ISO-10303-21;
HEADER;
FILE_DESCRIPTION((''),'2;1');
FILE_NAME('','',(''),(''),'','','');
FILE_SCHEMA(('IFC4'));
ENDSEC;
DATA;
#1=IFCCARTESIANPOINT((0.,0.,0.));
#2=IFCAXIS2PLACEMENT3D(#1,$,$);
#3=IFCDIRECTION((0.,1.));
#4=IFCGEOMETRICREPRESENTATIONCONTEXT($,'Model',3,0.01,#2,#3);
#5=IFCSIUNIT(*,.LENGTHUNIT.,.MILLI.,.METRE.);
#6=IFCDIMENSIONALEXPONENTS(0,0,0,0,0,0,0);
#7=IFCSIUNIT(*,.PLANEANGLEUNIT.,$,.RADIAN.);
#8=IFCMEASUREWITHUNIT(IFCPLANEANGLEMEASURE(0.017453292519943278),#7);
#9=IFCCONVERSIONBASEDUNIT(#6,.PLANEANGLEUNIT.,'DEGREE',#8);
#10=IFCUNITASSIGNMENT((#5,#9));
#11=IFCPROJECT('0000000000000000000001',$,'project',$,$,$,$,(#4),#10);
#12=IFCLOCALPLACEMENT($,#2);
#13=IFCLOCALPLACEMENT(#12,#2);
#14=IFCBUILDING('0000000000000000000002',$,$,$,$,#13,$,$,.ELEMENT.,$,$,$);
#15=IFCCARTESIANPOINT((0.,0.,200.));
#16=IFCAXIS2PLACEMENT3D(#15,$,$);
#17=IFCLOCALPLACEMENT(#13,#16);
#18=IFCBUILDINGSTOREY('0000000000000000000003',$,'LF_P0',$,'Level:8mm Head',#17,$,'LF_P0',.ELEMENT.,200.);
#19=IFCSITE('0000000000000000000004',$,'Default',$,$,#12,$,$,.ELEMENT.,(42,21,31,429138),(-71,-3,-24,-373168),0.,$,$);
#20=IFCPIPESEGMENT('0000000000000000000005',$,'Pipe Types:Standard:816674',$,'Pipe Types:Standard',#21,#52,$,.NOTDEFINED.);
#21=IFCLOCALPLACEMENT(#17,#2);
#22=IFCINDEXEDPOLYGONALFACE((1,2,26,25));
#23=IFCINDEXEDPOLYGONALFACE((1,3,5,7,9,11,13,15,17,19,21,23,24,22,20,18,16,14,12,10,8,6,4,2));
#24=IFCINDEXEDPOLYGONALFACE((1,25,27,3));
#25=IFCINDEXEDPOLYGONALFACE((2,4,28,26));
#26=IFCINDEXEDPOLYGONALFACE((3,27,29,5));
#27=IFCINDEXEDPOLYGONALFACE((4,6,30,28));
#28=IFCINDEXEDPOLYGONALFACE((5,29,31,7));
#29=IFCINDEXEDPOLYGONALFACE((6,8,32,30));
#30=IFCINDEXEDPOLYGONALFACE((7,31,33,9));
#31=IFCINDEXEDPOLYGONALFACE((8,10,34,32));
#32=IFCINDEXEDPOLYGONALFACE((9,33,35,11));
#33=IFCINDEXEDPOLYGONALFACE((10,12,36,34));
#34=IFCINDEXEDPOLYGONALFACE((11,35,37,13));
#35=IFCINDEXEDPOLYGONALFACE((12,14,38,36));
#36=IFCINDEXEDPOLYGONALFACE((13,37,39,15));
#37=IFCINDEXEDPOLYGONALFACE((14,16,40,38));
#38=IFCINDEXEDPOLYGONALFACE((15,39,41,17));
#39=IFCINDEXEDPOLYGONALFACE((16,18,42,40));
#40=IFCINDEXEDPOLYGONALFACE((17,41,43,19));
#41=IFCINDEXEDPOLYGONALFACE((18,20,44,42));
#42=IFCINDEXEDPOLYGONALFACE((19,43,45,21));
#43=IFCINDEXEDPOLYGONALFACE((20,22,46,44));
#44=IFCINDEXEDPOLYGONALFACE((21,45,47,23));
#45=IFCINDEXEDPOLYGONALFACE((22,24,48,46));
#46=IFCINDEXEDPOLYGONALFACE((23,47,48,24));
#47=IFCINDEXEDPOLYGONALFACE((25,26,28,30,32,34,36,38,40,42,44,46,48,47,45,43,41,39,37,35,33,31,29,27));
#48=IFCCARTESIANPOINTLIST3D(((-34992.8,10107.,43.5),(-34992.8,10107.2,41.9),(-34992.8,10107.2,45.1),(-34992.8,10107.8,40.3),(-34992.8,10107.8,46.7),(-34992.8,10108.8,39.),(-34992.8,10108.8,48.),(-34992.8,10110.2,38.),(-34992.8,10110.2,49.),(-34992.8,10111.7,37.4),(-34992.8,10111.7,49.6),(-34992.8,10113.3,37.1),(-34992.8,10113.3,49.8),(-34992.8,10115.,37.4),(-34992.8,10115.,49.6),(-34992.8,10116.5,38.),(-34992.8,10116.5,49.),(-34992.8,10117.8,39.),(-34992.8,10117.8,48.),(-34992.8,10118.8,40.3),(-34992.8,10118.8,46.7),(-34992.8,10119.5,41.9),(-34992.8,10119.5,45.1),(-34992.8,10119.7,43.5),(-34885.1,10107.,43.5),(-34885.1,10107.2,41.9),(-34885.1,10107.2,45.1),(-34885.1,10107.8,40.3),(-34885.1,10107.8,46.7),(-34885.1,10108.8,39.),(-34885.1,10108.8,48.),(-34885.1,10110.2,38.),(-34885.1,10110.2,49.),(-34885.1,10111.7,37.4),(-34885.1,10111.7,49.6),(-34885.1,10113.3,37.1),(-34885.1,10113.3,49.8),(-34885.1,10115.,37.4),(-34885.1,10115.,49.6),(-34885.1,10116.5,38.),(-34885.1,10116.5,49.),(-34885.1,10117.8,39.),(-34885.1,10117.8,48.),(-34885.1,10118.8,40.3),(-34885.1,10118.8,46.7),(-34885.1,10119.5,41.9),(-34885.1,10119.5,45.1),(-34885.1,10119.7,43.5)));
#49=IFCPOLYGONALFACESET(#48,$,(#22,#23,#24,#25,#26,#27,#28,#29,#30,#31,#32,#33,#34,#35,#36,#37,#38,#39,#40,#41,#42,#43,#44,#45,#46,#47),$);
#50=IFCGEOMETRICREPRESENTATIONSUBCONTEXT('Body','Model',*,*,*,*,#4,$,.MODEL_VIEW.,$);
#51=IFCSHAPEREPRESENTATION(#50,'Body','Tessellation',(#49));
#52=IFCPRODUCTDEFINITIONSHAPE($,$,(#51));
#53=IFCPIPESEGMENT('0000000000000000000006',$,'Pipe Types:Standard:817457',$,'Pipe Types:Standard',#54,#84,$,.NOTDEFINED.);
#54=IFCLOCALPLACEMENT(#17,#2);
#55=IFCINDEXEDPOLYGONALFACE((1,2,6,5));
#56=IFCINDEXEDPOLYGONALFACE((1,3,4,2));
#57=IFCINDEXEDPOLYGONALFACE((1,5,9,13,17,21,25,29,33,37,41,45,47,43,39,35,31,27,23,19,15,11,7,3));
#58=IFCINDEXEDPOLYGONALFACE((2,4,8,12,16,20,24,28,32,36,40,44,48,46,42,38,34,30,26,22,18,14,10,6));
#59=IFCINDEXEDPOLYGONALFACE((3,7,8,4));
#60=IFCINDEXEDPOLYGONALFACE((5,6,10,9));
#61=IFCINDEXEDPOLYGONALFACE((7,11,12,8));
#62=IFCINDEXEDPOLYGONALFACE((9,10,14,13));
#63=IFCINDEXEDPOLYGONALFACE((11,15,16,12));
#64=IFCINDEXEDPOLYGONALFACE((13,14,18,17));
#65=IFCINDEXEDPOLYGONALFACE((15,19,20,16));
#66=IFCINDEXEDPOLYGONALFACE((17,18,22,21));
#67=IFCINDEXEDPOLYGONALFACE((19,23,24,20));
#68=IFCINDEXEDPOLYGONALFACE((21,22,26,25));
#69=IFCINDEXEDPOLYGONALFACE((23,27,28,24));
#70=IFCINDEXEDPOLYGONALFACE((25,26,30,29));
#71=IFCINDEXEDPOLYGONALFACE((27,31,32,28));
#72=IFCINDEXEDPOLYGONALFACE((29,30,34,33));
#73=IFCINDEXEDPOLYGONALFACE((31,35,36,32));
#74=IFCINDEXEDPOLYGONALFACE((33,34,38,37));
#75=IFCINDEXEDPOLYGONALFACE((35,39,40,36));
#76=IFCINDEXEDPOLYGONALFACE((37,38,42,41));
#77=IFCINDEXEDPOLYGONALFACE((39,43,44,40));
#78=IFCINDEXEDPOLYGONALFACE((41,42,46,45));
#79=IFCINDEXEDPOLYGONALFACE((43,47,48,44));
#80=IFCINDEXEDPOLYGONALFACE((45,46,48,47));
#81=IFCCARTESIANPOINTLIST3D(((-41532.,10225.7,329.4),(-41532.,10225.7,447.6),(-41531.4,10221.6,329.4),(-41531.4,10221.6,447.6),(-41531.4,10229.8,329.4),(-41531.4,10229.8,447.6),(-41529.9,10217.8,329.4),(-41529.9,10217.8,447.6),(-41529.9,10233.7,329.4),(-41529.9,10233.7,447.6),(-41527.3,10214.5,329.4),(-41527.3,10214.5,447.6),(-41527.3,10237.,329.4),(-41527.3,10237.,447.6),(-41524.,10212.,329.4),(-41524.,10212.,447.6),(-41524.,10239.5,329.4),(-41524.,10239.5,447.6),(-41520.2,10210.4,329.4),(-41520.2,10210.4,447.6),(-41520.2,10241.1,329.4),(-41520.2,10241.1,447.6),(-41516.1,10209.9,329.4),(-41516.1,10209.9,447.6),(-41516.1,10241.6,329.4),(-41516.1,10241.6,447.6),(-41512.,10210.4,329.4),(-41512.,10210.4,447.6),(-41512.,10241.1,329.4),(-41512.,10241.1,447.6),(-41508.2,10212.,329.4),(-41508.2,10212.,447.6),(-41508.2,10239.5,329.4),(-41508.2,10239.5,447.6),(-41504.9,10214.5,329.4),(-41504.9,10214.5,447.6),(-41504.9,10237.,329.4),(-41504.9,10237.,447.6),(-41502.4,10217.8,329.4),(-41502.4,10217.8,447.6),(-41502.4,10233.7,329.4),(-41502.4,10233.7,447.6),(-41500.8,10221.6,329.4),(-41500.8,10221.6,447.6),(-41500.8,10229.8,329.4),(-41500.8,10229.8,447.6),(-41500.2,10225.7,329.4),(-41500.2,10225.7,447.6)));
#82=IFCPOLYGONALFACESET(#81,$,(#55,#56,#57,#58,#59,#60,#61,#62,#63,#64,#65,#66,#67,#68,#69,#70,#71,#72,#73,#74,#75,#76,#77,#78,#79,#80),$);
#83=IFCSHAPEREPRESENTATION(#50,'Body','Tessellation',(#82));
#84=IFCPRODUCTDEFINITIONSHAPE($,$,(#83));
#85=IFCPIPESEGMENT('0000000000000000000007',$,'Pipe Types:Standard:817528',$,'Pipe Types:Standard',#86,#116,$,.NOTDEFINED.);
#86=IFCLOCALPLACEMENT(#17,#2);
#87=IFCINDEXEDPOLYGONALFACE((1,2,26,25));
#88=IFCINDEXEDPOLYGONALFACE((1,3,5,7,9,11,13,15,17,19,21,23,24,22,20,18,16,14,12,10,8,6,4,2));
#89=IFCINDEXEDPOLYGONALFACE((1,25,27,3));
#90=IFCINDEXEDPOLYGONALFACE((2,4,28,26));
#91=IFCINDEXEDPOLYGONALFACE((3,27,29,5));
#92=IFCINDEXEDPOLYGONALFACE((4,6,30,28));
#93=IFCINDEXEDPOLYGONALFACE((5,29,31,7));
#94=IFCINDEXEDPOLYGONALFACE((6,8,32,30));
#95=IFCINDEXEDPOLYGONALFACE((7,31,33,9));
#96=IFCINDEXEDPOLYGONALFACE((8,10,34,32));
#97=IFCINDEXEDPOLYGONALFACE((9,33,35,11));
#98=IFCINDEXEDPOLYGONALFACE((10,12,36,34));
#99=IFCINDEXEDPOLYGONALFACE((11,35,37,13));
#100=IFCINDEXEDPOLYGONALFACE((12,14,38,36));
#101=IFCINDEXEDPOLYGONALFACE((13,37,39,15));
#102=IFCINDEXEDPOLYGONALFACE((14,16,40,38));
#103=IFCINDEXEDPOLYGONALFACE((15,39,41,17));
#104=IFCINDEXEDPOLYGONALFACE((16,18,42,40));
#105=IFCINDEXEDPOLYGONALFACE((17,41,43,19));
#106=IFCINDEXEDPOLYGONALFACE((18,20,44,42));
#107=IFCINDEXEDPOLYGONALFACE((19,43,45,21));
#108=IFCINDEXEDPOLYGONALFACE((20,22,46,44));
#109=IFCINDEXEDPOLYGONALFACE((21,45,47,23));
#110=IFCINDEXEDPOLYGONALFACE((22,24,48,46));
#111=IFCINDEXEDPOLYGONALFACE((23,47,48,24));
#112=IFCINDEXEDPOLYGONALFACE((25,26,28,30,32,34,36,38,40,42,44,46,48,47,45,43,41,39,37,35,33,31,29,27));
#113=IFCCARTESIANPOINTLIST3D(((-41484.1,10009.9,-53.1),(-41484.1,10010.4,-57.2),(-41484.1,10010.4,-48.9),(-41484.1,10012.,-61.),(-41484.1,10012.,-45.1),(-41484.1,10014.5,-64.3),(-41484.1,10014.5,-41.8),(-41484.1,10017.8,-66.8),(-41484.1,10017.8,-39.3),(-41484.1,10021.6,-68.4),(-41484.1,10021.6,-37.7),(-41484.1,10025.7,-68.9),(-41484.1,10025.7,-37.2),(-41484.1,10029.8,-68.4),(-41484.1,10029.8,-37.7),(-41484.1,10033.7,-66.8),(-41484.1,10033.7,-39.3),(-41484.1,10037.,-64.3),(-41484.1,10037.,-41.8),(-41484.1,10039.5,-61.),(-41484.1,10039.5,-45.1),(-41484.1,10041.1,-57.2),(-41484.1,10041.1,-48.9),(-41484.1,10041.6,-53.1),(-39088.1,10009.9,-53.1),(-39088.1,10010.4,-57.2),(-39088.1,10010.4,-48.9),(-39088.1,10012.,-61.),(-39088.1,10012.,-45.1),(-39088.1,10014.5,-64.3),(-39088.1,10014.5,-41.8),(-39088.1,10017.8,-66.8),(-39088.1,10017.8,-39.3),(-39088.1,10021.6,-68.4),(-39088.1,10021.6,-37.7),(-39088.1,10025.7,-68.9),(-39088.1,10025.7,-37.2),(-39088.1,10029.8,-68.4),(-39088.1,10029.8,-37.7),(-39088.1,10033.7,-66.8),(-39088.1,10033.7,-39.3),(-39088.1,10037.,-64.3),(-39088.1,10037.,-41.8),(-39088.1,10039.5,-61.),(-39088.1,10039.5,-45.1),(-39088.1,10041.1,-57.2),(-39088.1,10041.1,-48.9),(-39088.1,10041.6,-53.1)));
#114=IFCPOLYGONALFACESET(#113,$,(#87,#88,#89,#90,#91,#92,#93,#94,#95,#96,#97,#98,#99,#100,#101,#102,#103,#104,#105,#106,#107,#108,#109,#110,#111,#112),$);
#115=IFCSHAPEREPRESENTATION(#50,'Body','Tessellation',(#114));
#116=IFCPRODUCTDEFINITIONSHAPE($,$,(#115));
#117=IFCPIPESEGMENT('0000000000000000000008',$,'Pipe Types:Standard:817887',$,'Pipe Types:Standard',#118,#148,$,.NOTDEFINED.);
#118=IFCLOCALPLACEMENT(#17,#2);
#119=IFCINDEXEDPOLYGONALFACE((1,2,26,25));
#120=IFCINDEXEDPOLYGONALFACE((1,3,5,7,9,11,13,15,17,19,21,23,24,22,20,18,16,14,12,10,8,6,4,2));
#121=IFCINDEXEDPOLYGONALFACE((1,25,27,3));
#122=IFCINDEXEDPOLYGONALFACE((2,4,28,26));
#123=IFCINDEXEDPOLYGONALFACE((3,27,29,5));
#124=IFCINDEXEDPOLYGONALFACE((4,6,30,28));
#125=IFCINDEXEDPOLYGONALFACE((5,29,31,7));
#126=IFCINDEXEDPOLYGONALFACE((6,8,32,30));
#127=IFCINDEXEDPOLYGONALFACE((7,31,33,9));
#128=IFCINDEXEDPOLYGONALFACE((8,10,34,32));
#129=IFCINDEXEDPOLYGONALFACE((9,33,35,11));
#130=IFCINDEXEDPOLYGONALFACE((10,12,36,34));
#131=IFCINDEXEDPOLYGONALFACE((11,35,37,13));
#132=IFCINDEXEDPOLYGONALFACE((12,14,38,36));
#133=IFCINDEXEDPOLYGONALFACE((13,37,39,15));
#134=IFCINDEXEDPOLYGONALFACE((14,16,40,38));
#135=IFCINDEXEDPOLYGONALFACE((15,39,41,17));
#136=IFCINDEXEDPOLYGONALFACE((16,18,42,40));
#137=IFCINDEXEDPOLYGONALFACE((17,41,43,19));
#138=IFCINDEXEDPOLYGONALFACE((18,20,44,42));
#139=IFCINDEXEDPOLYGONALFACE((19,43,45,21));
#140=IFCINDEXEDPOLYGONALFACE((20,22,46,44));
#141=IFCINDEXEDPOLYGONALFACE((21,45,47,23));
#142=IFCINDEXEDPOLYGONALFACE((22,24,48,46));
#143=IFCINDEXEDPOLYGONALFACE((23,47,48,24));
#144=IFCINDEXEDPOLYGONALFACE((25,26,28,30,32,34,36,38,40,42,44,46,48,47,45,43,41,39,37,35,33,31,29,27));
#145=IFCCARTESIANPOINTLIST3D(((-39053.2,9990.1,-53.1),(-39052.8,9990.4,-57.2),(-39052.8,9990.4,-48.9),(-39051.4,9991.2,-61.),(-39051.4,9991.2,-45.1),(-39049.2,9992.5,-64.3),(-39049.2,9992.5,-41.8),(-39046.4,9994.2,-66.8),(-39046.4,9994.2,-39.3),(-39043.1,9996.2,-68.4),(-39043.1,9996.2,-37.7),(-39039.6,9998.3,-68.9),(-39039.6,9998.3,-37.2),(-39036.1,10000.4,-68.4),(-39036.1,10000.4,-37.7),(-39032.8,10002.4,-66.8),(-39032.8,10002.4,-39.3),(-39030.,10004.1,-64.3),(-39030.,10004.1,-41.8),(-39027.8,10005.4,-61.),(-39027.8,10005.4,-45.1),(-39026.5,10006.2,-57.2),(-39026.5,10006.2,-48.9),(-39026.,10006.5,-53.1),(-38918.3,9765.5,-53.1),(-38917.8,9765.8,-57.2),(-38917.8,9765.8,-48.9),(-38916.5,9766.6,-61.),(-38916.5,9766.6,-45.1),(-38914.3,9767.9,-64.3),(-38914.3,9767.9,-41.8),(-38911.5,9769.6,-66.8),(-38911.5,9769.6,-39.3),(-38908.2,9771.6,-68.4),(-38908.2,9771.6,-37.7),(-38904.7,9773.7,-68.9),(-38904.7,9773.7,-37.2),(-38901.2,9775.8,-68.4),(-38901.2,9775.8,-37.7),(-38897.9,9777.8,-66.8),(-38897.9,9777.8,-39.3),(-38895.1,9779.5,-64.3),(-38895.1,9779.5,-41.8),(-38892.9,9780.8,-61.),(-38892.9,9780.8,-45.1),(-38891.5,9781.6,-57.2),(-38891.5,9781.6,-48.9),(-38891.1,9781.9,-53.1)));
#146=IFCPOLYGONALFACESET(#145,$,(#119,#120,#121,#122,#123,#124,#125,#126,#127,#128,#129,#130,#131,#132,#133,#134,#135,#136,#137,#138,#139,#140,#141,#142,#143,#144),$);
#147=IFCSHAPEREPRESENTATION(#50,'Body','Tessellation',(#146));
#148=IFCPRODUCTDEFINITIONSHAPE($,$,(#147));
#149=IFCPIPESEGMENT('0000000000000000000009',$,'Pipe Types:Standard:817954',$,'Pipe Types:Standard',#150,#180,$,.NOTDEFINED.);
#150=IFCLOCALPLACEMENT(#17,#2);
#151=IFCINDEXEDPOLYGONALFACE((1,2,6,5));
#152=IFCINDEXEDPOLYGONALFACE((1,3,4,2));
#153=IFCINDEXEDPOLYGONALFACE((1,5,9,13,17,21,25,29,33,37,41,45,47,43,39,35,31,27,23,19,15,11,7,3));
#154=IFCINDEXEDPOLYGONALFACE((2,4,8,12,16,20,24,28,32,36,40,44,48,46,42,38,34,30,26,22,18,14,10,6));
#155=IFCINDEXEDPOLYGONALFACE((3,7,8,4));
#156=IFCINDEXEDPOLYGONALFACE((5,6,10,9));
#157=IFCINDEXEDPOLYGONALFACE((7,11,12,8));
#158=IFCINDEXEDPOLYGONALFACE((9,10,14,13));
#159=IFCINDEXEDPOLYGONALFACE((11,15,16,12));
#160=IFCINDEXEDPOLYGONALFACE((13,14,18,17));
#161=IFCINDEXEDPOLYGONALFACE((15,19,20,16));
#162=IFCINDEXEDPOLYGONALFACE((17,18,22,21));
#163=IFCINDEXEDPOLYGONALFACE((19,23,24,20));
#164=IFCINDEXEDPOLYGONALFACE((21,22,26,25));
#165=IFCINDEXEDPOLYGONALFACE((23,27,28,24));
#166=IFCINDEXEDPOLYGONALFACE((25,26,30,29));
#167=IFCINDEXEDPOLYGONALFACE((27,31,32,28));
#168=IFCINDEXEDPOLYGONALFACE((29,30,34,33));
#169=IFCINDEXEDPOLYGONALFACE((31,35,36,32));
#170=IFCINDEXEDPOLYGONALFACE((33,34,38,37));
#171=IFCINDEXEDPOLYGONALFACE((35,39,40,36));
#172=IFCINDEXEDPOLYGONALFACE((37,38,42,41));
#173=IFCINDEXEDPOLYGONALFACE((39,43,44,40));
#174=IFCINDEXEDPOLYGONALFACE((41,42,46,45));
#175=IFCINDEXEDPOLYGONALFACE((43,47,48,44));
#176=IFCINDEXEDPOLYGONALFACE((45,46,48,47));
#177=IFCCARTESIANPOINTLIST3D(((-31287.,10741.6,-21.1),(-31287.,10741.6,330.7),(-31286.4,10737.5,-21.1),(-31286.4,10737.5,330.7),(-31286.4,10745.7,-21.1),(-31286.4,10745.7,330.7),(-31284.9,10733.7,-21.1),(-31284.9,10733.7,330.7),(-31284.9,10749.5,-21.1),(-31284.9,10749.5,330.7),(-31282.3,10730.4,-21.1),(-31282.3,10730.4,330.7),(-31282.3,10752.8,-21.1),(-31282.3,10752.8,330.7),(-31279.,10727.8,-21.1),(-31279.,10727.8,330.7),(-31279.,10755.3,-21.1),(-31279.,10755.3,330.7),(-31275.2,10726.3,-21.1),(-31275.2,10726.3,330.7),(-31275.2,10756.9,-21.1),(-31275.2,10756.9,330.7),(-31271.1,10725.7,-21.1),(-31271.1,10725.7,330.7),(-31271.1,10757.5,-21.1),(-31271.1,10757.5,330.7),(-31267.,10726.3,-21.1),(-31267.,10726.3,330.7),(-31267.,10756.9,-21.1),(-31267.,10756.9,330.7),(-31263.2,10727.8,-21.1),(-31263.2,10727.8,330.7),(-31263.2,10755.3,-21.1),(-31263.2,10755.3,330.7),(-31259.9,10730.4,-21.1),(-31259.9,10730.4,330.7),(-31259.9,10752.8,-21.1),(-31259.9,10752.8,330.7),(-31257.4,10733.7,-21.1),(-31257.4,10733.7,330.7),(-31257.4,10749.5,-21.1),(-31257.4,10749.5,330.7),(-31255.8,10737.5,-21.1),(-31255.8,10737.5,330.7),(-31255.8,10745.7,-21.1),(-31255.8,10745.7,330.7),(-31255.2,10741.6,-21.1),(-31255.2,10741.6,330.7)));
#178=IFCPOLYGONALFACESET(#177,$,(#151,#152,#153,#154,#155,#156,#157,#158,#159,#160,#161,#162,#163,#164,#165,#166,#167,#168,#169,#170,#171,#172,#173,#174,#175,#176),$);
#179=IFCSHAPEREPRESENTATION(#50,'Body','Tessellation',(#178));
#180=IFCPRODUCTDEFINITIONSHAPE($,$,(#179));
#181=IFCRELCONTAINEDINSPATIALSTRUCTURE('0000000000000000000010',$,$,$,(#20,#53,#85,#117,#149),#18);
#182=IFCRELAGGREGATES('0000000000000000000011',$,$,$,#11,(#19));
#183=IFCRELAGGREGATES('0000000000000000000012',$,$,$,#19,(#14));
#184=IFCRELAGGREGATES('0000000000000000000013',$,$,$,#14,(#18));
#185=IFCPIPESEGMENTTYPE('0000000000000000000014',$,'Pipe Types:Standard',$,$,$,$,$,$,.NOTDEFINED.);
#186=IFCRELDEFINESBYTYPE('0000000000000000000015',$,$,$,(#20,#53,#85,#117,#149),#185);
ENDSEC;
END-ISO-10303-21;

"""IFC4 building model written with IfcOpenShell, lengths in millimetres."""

from ifc_helpers import new_model, entity, si_unit, converted_unit, direction, frame, origin, place, context, subcontext, project, spatial, arc, indexed_curve, outline, extrude, type_object, element, save


model = new_model("IFC4")

# Units and contexts
model_context = context("Model", 3, precision=0.01, world=origin(), true_north=direction((0.0, 1.0)))
body_context = subcontext(model_context, "Body", "Model", "MODEL_VIEW")
ifc_project = project(units=[si_unit("LENGTHUNIT", "METRE", prefix="MILLI"), converted_unit("PLANEANGLEUNIT", "DEGREE", entity("IfcPlaneAngleMeasure", 0.017453292519943278), si_unit("PLANEANGLEUNIT", "RADIAN"), dimensions=[0, 0, 0, 0, 0, 0, 0])], contexts=[model_context])

# Site, building, storey
site_placement = place(None, origin())
site = spatial("IfcSite", under=ifc_project, at=site_placement, Name="Default", CompositionType="ELEMENT", RefLatitude=(42, 21, 31, 429138), RefLongitude=(-71, -3, -24, -373168), RefElevation=0.0)
building_placement = place(site_placement, origin())
building = spatial("IfcBuilding", under=site, at=building_placement, CompositionType="ELEMENT")
storey_placement = place(building_placement, frame((0.0, 0.0, 200.0)))
storey = spatial("IfcBuildingStorey", under=building, at=storey_placement, Name="LF_P0", ObjectType="Level:8mm Head", LongName="LF_P0", CompositionType="ELEMENT", Elevation=200.0)

# Pipe segments
pipe_segment_type_1 = type_object("IfcPipeSegmentType", Name="Pipe Types:Standard", PredefinedType="NOTDEFINED")
pipe_segment_1_placement = place(storey_placement, origin())
element("IfcPipeSegment", 1, at=pipe_segment_1_placement, inside=storey, type_object=pipe_segment_type_1, Name="Pipe Types:Standard:816674", ObjectType="Pipe Types:Standard", PredefinedType="NOTDEFINED", context=body_context, shape_type="SweptSolid", body=[
    extrude(outline(indexed_curve([(6.4, 0.0), (4.5, 4.5), (0.0, 6.4), (-4.5, 4.5), (-6.3, 0.0), (-4.5, -4.5), (0.0, -6.4), (4.5, -4.5)], segments=[arc(1, 2, 3), arc(3, 4, 5), arc(5, 6, 7), arc(7, 8, 1)], self_intersect=False)), frame((-34992.8, 10113.3, 43.5), z_axis=(1.0, 0.0, 0.0), x_axis=(0.0, 1.0, 0.0)), (0.0, 0.0, 1.0), 107.7),
])
pipe_segment_2_placement = place(storey_placement, origin())
element("IfcPipeSegment", 2, at=pipe_segment_2_placement, inside=storey, type_object=pipe_segment_type_1, Name="Pipe Types:Standard:817457", ObjectType="Pipe Types:Standard", PredefinedType="NOTDEFINED", context=body_context, shape_type="SweptSolid", body=[
    extrude(outline(indexed_curve([(15.9, 0.0), (11.2, 11.2), (0.0, 15.9), (-11.2, 11.2), (-15.9, 0.0), (-11.2, -11.2), (0.0, -15.9), (11.2, -11.2)], segments=[arc(1, 2, 3), arc(3, 4, 5), arc(5, 6, 7), arc(7, 8, 1)], self_intersect=False)), frame((-41516.1, 10225.7, 329.4)), (0.0, 0.0, 1.0), 118.2),
])
pipe_segment_3_placement = place(storey_placement, origin())
element("IfcPipeSegment", 3, at=pipe_segment_3_placement, inside=storey, type_object=pipe_segment_type_1, Name="Pipe Types:Standard:817528", ObjectType="Pipe Types:Standard", PredefinedType="NOTDEFINED", context=body_context, shape_type="SweptSolid", body=[
    extrude(outline(indexed_curve([(15.9, 0.0), (11.2, 11.2), (0.0, 15.9), (-11.2, 11.2), (-15.9, 0.0), (-11.2, -11.2), (0.0, -15.9), (11.2, -11.2)], segments=[arc(1, 2, 3), arc(3, 4, 5), arc(5, 6, 7), arc(7, 8, 1)], self_intersect=False)), frame((-41484.1, 10025.7, -53.1), z_axis=(1.0, 0.0, 0.0), x_axis=(0.0, -1.0, 0.0)), (0.0, 0.0, 1.0), 2396.0),
])
pipe_segment_4_placement = place(storey_placement, origin())
element("IfcPipeSegment", 4, at=pipe_segment_4_placement, inside=storey, type_object=pipe_segment_type_1, Name="Pipe Types:Standard:817887", ObjectType="Pipe Types:Standard", PredefinedType="NOTDEFINED", context=body_context, shape_type="SweptSolid", body=[
    extrude(outline(indexed_curve([(15.9, 0.0), (11.2, 11.2), (0.0, 15.9), (-11.2, 11.2), (-15.9, 0.0), (-11.2, -11.2), (0.0, -15.9), (11.2, -11.2)], segments=[arc(1, 2, 3), arc(3, 4, 5), arc(5, 6, 7), arc(7, 8, 1)], self_intersect=False)), frame((-38904.7, 9773.7, -53.1), z_axis=(-0.515038, 0.857167, 0.0), x_axis=(0.857167, 0.515038, 0.0)), (0.0, 0.0, 1.0), 262.0),
])
pipe_segment_5_placement = place(storey_placement, origin())
element("IfcPipeSegment", 5, at=pipe_segment_5_placement, inside=storey, type_object=pipe_segment_type_1, Name="Pipe Types:Standard:817954", ObjectType="Pipe Types:Standard", PredefinedType="NOTDEFINED", context=body_context, shape_type="SweptSolid", body=[
    extrude(outline(indexed_curve([(15.9, 0.0), (11.2, 11.2), (0.0, 15.9), (-11.2, 11.2), (-15.9, 0.0), (-11.2, -11.2), (0.0, -15.9), (11.2, -11.2)], segments=[arc(1, 2, 3), arc(3, 4, 5), arc(5, 6, 7), arc(7, 8, 1)], self_intersect=False)), frame((-31271.1, 10741.6, -21.1), z_axis=(0.0, 0.0, 1.0), x_axis=(-1.0, 0.0, 0.0)), (0.0, 0.0, 1.0), 351.8),
])

save(model, "model.ifc")
